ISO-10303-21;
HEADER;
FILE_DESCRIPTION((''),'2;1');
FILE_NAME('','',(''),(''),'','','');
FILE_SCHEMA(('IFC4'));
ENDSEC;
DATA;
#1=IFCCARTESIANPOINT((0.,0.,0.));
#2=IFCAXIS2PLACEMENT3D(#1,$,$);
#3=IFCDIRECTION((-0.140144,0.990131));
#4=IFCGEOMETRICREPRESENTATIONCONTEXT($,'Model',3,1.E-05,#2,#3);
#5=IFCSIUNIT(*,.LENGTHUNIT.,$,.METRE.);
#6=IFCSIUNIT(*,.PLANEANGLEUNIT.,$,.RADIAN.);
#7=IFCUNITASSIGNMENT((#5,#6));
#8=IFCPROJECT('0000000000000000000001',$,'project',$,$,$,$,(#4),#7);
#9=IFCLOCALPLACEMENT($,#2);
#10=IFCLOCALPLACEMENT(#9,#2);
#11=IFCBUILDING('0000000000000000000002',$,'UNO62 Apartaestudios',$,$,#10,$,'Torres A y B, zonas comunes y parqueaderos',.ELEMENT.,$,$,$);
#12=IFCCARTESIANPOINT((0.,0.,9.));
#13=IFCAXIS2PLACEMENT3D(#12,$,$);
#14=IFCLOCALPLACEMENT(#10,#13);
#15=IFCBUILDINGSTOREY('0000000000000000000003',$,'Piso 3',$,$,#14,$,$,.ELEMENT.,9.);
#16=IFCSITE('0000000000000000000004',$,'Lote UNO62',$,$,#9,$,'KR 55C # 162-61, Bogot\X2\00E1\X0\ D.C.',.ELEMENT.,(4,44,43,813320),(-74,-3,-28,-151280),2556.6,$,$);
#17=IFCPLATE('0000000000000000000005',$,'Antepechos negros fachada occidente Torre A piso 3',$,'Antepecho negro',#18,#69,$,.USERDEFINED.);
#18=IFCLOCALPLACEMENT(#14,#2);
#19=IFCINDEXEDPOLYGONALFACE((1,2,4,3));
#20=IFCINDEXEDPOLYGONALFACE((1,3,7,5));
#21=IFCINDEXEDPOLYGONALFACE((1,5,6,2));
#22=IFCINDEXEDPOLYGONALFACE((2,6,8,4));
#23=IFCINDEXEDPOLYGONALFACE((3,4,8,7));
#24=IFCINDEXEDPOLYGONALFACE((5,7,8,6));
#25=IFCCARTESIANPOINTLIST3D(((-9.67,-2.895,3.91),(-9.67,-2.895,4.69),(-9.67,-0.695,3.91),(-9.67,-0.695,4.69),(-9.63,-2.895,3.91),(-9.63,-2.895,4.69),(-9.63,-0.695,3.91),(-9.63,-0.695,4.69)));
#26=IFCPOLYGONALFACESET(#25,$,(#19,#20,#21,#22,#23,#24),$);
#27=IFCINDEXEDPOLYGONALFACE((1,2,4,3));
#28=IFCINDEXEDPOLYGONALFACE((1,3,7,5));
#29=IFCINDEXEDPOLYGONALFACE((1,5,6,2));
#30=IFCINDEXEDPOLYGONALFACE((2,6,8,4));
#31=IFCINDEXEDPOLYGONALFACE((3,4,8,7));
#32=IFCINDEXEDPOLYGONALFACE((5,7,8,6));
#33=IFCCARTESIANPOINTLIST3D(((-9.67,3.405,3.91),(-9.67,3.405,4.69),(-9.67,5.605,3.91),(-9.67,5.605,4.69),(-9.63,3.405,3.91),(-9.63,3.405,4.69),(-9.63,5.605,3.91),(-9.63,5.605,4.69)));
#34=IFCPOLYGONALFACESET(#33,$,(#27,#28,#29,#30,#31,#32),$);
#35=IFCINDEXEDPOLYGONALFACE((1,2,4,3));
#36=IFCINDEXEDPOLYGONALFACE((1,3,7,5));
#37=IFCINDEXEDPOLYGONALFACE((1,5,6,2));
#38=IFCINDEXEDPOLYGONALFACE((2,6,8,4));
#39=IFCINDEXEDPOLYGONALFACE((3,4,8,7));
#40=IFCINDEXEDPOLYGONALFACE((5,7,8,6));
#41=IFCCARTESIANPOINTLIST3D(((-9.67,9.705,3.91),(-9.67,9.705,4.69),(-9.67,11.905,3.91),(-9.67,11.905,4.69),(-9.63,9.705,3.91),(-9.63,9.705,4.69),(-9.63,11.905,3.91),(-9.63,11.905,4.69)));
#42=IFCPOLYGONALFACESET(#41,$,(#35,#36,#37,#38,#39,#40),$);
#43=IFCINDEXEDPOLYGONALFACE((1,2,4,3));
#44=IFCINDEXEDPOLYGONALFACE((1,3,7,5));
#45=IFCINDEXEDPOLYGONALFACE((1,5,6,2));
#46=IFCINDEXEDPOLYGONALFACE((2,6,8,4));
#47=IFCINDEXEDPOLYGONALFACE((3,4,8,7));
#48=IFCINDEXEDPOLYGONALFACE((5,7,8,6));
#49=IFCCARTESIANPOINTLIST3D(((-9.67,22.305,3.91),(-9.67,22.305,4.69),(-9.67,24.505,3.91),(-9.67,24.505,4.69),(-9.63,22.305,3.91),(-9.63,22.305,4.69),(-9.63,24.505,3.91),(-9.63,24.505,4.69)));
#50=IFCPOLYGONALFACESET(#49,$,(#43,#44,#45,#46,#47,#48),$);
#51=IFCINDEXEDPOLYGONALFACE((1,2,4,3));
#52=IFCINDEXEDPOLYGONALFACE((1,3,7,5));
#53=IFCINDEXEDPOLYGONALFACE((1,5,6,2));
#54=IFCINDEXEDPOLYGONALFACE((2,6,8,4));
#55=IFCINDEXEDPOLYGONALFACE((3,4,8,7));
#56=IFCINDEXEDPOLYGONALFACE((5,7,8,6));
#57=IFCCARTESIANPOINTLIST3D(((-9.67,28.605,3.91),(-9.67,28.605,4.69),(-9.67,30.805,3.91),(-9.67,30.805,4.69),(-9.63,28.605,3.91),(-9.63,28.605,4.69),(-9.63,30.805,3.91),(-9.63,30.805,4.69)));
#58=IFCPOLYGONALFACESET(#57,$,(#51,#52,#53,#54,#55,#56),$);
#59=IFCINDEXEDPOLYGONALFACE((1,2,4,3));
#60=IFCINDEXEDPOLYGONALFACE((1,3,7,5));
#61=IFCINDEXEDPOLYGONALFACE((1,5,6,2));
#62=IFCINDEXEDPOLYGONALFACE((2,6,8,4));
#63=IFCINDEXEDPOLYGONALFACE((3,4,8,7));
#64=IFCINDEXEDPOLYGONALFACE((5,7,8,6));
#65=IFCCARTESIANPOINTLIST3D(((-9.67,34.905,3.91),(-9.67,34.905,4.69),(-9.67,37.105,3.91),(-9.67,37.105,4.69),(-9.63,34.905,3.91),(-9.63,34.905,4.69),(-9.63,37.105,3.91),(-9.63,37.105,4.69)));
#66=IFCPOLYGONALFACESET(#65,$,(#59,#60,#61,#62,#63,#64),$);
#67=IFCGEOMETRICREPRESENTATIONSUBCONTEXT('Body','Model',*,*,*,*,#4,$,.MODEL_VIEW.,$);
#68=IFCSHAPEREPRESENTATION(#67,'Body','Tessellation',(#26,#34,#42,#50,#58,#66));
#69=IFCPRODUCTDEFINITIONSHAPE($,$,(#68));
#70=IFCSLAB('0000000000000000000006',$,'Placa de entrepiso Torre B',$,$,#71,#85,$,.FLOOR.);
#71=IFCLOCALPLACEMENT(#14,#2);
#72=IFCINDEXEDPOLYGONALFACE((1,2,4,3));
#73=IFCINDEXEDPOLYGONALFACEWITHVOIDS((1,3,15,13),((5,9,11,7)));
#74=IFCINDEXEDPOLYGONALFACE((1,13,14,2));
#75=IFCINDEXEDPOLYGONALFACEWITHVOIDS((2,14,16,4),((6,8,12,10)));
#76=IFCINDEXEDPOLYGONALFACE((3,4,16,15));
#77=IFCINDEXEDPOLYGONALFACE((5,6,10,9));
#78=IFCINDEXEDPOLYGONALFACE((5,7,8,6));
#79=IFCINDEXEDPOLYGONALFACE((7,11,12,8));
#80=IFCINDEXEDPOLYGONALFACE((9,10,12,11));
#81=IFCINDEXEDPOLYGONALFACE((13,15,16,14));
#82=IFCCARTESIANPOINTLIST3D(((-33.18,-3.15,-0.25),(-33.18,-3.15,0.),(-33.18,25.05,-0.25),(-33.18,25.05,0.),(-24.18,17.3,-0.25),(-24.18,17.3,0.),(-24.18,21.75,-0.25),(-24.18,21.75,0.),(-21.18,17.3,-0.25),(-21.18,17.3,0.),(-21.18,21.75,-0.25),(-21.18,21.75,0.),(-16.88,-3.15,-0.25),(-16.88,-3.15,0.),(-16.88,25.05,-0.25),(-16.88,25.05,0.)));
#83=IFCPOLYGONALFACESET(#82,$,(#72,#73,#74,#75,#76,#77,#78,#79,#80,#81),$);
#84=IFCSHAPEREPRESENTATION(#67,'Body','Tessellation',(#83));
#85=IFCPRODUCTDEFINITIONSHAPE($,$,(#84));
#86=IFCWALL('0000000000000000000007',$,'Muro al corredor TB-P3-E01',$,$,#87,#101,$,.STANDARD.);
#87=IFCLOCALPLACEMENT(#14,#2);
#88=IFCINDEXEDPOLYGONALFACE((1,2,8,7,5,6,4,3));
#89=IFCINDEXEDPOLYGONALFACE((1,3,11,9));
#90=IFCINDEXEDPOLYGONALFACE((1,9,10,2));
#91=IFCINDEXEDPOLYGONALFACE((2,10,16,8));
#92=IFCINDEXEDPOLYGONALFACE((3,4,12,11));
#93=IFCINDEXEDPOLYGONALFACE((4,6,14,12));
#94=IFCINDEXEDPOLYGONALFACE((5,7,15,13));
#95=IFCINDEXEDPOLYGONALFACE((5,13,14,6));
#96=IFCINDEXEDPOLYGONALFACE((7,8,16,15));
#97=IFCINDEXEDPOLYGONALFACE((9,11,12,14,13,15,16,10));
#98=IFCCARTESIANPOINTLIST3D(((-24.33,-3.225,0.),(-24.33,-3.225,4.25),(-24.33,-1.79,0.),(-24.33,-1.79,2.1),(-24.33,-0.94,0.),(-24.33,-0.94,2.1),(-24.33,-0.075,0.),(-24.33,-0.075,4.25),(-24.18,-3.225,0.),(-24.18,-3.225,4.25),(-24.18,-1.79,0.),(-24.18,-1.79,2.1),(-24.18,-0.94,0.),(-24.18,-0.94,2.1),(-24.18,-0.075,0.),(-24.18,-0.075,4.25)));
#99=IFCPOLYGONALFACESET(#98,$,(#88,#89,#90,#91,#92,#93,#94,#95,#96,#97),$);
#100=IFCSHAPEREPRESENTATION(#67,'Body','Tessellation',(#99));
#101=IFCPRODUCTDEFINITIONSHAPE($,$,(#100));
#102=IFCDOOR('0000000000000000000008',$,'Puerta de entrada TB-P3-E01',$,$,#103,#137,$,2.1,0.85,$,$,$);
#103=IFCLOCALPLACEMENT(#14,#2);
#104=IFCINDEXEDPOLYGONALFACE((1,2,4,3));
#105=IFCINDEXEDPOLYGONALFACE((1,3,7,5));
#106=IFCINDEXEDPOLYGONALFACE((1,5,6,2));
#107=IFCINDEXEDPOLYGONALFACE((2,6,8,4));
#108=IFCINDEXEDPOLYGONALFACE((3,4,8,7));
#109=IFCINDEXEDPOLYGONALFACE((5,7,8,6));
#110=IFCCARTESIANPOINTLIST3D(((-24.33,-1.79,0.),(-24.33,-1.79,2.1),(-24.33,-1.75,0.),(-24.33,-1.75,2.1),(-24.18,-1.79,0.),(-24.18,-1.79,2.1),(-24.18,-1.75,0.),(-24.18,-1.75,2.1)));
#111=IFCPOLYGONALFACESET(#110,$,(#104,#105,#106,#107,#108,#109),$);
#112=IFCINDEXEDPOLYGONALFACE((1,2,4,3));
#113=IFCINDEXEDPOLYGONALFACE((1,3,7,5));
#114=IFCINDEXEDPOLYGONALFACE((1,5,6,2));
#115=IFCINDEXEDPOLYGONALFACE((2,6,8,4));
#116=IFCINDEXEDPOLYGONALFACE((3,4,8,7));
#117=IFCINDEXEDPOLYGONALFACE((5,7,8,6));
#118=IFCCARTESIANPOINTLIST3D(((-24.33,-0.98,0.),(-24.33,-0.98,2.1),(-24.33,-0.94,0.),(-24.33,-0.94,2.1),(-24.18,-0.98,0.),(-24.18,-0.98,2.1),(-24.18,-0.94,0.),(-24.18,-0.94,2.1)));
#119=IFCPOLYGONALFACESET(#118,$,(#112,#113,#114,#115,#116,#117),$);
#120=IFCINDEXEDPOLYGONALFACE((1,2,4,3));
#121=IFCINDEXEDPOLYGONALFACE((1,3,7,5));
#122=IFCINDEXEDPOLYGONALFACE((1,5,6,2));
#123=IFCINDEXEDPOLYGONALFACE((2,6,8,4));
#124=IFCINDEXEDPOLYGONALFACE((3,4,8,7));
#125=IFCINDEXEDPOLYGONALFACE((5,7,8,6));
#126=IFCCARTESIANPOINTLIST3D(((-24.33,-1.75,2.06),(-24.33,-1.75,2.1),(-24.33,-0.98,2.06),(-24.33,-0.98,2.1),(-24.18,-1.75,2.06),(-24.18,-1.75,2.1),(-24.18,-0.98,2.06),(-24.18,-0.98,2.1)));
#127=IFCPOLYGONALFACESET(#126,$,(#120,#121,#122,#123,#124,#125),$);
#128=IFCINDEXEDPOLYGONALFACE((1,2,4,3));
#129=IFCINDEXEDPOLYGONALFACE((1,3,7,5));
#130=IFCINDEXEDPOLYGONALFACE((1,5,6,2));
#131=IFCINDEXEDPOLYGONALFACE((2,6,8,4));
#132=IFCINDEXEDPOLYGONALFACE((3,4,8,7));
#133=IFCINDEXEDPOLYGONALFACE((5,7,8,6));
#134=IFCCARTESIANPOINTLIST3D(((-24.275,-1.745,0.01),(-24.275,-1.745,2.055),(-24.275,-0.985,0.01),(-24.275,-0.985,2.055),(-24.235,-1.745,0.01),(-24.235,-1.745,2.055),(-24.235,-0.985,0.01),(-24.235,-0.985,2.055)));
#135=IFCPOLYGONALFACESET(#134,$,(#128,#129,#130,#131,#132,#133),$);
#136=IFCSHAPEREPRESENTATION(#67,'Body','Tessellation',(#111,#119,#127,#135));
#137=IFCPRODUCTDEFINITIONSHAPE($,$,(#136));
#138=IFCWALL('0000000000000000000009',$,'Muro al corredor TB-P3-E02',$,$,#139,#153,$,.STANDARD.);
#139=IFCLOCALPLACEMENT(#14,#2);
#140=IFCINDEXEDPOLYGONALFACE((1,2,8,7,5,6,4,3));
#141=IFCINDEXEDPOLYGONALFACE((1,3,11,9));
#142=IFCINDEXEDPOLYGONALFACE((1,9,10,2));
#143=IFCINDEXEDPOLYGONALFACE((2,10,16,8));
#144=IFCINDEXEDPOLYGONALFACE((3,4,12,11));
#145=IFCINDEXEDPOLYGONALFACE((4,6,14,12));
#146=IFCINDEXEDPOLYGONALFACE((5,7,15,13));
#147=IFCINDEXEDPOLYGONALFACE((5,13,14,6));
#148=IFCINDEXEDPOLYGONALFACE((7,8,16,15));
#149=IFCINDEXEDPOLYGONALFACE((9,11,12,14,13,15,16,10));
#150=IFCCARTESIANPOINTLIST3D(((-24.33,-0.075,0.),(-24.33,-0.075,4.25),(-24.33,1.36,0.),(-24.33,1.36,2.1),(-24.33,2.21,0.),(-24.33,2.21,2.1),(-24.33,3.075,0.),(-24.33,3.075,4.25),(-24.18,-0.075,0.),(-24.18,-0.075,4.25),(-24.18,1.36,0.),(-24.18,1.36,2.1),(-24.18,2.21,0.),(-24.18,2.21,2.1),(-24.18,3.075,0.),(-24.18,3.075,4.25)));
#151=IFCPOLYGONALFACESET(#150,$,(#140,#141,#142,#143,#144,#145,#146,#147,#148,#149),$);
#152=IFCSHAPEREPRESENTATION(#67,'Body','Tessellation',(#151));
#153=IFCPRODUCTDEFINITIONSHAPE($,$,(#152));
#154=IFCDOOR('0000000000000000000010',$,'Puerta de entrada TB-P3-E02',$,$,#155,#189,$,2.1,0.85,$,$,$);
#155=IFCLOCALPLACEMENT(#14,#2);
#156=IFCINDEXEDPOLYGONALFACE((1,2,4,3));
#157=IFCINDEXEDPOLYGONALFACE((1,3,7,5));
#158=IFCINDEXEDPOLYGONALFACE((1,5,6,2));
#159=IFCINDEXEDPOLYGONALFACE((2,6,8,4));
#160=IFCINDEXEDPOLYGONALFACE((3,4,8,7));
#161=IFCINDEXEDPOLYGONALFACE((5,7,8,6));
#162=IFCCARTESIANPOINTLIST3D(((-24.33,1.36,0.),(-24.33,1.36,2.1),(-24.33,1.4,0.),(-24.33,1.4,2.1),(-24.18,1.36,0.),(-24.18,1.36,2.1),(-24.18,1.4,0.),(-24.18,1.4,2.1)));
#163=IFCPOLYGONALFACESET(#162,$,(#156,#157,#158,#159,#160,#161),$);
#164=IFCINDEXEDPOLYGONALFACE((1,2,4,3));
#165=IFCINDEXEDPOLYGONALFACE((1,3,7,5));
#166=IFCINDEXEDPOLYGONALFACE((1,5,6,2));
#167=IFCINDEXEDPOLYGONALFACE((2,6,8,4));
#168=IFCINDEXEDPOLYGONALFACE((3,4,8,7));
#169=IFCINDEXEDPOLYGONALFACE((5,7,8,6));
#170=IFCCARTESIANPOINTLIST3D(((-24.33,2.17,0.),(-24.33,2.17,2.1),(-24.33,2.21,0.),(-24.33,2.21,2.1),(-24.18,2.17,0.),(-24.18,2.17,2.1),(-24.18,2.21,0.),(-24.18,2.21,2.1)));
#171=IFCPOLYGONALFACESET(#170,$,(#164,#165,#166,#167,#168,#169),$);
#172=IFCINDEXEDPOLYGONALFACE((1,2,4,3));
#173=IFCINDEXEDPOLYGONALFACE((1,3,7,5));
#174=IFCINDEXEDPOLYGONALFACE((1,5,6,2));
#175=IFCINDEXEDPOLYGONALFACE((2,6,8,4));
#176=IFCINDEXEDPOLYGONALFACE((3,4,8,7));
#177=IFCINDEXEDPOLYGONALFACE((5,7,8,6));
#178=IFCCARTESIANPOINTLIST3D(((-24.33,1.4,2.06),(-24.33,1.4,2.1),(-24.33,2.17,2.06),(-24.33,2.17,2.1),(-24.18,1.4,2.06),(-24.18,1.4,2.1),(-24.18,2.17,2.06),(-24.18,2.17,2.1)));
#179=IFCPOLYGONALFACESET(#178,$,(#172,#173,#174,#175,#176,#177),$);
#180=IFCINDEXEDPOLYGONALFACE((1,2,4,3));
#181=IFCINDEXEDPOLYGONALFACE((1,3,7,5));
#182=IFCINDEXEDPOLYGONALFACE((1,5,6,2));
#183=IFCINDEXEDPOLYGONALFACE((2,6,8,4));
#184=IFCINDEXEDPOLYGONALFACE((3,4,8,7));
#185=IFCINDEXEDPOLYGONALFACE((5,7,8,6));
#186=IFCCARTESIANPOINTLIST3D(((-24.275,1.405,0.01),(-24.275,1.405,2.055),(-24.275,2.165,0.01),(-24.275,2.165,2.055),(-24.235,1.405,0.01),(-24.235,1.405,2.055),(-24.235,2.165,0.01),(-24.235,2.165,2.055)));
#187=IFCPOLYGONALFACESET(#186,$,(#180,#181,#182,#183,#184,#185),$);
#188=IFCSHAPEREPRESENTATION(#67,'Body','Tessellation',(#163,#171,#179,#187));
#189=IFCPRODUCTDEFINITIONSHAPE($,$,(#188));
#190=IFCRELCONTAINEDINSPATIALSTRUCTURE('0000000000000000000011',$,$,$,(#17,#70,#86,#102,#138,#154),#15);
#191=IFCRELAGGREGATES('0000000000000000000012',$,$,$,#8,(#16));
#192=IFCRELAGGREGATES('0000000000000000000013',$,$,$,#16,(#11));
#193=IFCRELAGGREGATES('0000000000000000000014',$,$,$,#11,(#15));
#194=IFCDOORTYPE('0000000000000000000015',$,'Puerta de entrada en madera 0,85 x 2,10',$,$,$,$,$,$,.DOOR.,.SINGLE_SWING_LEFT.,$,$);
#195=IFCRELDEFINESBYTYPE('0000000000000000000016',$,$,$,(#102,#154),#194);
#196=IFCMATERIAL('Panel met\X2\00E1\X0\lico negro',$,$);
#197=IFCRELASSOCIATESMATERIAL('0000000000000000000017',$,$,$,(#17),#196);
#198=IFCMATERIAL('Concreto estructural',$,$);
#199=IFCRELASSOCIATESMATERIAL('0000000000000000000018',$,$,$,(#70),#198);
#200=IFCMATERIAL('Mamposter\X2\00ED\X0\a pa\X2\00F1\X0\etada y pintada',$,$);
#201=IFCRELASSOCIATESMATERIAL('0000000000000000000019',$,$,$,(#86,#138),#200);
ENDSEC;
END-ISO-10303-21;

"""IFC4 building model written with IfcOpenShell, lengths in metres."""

from ifc_helpers import new_model, si_unit, direction, frame, frame_2d, origin, place, context, subcontext, project, spatial, rectangle, extrude, source, transform, mapped, material, type_object, type_shapes, element, fill, save


model = new_model("IFC4")

# Units and contexts
model_context = context("Model", 3, precision=1e-05, world=origin(), true_north=direction((-0.140144, 0.990131)))
body_context = subcontext(model_context, "Body", "Model", "MODEL_VIEW")
ifc_project = project(units=[si_unit("LENGTHUNIT", "METRE"), si_unit("PLANEANGLEUNIT", "RADIAN")], contexts=[model_context])

# Site, building, storey
site_placement = place(None, origin())
site = spatial("IfcSite", under=ifc_project, at=site_placement, Name="Lote UNO62", LongName="KR 55C # 162-61, Bogotá D.C.", CompositionType="ELEMENT", RefLatitude=(4, 44, 43, 813320), RefLongitude=(-74, -3, -28, -151280), RefElevation=2556.6)
building_placement = place(site_placement, origin())
building = spatial("IfcBuilding", under=site, at=building_placement, Name="UNO62 Apartaestudios", LongName="Torres A y B, zonas comunes y parqueaderos", CompositionType="ELEMENT")
storey_placement = place(building_placement, frame((0.0, 0.0, 9.0)))
storey = spatial("IfcBuildingStorey", under=building, at=storey_placement, Name="Piso 3", CompositionType="ELEMENT", Elevation=9.0)

# Plate
ifc_material_1 = material(Name="Panel metálico negro")
plate_placement = place(storey_placement, origin())
element("IfcPlate", 1, at=plate_placement, inside=storey, material=ifc_material_1, Name="Antepechos negros fachada occidente Torre A piso 3", ObjectType="Antepecho negro", PredefinedType="USERDEFINED", context=body_context, shape_type="SweptSolid", body=[
    extrude(rectangle(XDim=0.04, YDim=2.2, at=frame_2d((-9.65, -1.795))), frame((0.0, 0.0, 3.91)), (0.0, 0.0, 1.0), 0.78),
    extrude(rectangle(XDim=0.04, YDim=2.2, at=frame_2d((-9.65, 4.505))), frame((0.0, 0.0, 3.91)), (0.0, 0.0, 1.0), 0.78),
    extrude(rectangle(XDim=0.04, YDim=2.2, at=frame_2d((-9.65, 10.805))), frame((0.0, 0.0, 3.91)), (0.0, 0.0, 1.0), 0.78),
    extrude(rectangle(XDim=0.04, YDim=2.2, at=frame_2d((-9.65, 23.405))), frame((0.0, 0.0, 3.91)), (0.0, 0.0, 1.0), 0.78),
    extrude(rectangle(XDim=0.04, YDim=2.2, at=frame_2d((-9.65, 29.705))), frame((0.0, 0.0, 3.91)), (0.0, 0.0, 1.0), 0.78),
    extrude(rectangle(XDim=0.04, YDim=2.2, at=frame_2d((-9.65, 36.005))), frame((0.0, 0.0, 3.91)), (0.0, 0.0, 1.0), 0.78),
])

# Slab, opening
ifc_material_2 = material(Name="Concreto estructural")
slab_placement = place(storey_placement, origin())
slab = element("IfcSlab", 2, at=slab_placement, inside=storey, material=ifc_material_2, Name="Placa de entrepiso Torre B", PredefinedType="FLOOR", context=body_context, shape_type="SweptSolid", body=[
    extrude(rectangle(XDim=16.3, YDim=28.2, at=frame_2d((-25.03, 10.95))), frame((0.0, 0.0, -0.25)), (0.0, 0.0, 1.0), 0.25),
])
opening_1_placement = place(slab_placement, origin())
element("IfcOpeningElement", 3, at=opening_1_placement, cuts=slab, PredefinedType="OPENING", context=body_context, shape_type="SweptSolid", body=[
    extrude(rectangle(XDim=3.0, YDim=4.45, at=frame_2d((-22.68, 19.525))), frame((0.0, 0.0, -0.3)), (0.0, 0.0, 1.0), 0.35),
])

# Shared definitions
placement_1 = place(storey_placement, frame((-24.18, -3.15, 0.0)))
placement_2 = place(storey_placement, frame((-24.18, 0.0, 0.0)))

# Walls, openings, doors
ifc_material_3 = material(Name="Mampostería pañetada y pintada")
wall_1_placement = place(storey_placement, origin())
wall_1 = element("IfcWall", 4, at=wall_1_placement, inside=storey, material=ifc_material_3, Name="Muro al corredor TB-P3-E01", PredefinedType="STANDARD", context=body_context, shape_type="SweptSolid", body=[
    extrude(rectangle(XDim=0.15, YDim=3.15, at=frame_2d((-24.255, -1.65))), origin(), (0.0, 0.0, 1.0), 4.25),
])
opening_2_placement = place(wall_1_placement, origin())
opening_2 = element("IfcOpeningElement", 5, at=opening_2_placement, cuts=wall_1, PredefinedType="OPENING", context=body_context, shape_type="SweptSolid", body=[
    extrude(rectangle(XDim=0.25, YDim=0.85, at=frame_2d((-24.255, -1.365))), origin(), (0.0, 0.0, 1.0), 2.1),
])
door_type_1 = type_object("IfcDoorType", Name="Puerta de entrada en madera 0,85 x 2,10", OperationType="SINGLE_SWING_LEFT", PredefinedType="DOOR")
shared_shape_1 = source(origin(), body_context, "Body", "SweptSolid", [
    extrude(rectangle(XDim=0.15, YDim=0.04, at=frame_2d((-0.075, 1.38))), origin(), (0.0, 0.0, 1.0), 2.1),
    extrude(rectangle(XDim=0.15, YDim=0.04, at=frame_2d((-0.075, 2.19))), origin(), (0.0, 0.0, 1.0), 2.1),
    extrude(rectangle(XDim=0.15, YDim=0.77, at=frame_2d((-0.075, 1.785))), frame((0.0, 0.0, 2.06)), (0.0, 0.0, 1.0), 0.04),
    extrude(rectangle(XDim=0.04, YDim=0.76, at=frame_2d((-0.075, 1.785))), frame((0.0, 0.0, 0.01)), (0.0, 0.0, 1.0), 2.045),
])
type_shapes(door_type_1, [shared_shape_1])
door_1_placement = place(placement_1, origin())
door_1 = element("IfcDoor", 6, at=door_1_placement, inside=storey, type_object=door_type_1, Name="Puerta de entrada TB-P3-E01", OverallHeight=2.1, OverallWidth=0.85, context=body_context, shape_type="MappedRepresentation", body=[
    mapped(shared_shape_1, transform((0.0, 0.0, 0.0))),
])
fill(opening_2, door_1)
wall_2_placement = place(storey_placement, origin())
wall_2 = element("IfcWall", 7, at=wall_2_placement, inside=storey, material=ifc_material_3, Name="Muro al corredor TB-P3-E02", PredefinedType="STANDARD", context=body_context, shape_type="SweptSolid", body=[
    extrude(rectangle(XDim=0.15, YDim=3.15, at=frame_2d((-24.255, 1.5))), origin(), (0.0, 0.0, 1.0), 4.25),
])
opening_3_placement = place(wall_2_placement, origin())
opening_3 = element("IfcOpeningElement", 8, at=opening_3_placement, cuts=wall_2, PredefinedType="OPENING", context=body_context, shape_type="SweptSolid", body=[
    extrude(rectangle(XDim=0.25, YDim=0.85, at=frame_2d((-24.255, 1.785))), origin(), (0.0, 0.0, 1.0), 2.1),
])
door_2_placement = place(placement_2, origin())
door_2 = element("IfcDoor", 9, at=door_2_placement, inside=storey, type_object=door_type_1, Name="Puerta de entrada TB-P3-E02", OverallHeight=2.1, OverallWidth=0.85, context=body_context, shape_type="MappedRepresentation", body=[
    mapped(shared_shape_1, transform((0.0, 0.0, 0.0))),
])
fill(opening_3, door_2)

save(model, "model.ifc")
